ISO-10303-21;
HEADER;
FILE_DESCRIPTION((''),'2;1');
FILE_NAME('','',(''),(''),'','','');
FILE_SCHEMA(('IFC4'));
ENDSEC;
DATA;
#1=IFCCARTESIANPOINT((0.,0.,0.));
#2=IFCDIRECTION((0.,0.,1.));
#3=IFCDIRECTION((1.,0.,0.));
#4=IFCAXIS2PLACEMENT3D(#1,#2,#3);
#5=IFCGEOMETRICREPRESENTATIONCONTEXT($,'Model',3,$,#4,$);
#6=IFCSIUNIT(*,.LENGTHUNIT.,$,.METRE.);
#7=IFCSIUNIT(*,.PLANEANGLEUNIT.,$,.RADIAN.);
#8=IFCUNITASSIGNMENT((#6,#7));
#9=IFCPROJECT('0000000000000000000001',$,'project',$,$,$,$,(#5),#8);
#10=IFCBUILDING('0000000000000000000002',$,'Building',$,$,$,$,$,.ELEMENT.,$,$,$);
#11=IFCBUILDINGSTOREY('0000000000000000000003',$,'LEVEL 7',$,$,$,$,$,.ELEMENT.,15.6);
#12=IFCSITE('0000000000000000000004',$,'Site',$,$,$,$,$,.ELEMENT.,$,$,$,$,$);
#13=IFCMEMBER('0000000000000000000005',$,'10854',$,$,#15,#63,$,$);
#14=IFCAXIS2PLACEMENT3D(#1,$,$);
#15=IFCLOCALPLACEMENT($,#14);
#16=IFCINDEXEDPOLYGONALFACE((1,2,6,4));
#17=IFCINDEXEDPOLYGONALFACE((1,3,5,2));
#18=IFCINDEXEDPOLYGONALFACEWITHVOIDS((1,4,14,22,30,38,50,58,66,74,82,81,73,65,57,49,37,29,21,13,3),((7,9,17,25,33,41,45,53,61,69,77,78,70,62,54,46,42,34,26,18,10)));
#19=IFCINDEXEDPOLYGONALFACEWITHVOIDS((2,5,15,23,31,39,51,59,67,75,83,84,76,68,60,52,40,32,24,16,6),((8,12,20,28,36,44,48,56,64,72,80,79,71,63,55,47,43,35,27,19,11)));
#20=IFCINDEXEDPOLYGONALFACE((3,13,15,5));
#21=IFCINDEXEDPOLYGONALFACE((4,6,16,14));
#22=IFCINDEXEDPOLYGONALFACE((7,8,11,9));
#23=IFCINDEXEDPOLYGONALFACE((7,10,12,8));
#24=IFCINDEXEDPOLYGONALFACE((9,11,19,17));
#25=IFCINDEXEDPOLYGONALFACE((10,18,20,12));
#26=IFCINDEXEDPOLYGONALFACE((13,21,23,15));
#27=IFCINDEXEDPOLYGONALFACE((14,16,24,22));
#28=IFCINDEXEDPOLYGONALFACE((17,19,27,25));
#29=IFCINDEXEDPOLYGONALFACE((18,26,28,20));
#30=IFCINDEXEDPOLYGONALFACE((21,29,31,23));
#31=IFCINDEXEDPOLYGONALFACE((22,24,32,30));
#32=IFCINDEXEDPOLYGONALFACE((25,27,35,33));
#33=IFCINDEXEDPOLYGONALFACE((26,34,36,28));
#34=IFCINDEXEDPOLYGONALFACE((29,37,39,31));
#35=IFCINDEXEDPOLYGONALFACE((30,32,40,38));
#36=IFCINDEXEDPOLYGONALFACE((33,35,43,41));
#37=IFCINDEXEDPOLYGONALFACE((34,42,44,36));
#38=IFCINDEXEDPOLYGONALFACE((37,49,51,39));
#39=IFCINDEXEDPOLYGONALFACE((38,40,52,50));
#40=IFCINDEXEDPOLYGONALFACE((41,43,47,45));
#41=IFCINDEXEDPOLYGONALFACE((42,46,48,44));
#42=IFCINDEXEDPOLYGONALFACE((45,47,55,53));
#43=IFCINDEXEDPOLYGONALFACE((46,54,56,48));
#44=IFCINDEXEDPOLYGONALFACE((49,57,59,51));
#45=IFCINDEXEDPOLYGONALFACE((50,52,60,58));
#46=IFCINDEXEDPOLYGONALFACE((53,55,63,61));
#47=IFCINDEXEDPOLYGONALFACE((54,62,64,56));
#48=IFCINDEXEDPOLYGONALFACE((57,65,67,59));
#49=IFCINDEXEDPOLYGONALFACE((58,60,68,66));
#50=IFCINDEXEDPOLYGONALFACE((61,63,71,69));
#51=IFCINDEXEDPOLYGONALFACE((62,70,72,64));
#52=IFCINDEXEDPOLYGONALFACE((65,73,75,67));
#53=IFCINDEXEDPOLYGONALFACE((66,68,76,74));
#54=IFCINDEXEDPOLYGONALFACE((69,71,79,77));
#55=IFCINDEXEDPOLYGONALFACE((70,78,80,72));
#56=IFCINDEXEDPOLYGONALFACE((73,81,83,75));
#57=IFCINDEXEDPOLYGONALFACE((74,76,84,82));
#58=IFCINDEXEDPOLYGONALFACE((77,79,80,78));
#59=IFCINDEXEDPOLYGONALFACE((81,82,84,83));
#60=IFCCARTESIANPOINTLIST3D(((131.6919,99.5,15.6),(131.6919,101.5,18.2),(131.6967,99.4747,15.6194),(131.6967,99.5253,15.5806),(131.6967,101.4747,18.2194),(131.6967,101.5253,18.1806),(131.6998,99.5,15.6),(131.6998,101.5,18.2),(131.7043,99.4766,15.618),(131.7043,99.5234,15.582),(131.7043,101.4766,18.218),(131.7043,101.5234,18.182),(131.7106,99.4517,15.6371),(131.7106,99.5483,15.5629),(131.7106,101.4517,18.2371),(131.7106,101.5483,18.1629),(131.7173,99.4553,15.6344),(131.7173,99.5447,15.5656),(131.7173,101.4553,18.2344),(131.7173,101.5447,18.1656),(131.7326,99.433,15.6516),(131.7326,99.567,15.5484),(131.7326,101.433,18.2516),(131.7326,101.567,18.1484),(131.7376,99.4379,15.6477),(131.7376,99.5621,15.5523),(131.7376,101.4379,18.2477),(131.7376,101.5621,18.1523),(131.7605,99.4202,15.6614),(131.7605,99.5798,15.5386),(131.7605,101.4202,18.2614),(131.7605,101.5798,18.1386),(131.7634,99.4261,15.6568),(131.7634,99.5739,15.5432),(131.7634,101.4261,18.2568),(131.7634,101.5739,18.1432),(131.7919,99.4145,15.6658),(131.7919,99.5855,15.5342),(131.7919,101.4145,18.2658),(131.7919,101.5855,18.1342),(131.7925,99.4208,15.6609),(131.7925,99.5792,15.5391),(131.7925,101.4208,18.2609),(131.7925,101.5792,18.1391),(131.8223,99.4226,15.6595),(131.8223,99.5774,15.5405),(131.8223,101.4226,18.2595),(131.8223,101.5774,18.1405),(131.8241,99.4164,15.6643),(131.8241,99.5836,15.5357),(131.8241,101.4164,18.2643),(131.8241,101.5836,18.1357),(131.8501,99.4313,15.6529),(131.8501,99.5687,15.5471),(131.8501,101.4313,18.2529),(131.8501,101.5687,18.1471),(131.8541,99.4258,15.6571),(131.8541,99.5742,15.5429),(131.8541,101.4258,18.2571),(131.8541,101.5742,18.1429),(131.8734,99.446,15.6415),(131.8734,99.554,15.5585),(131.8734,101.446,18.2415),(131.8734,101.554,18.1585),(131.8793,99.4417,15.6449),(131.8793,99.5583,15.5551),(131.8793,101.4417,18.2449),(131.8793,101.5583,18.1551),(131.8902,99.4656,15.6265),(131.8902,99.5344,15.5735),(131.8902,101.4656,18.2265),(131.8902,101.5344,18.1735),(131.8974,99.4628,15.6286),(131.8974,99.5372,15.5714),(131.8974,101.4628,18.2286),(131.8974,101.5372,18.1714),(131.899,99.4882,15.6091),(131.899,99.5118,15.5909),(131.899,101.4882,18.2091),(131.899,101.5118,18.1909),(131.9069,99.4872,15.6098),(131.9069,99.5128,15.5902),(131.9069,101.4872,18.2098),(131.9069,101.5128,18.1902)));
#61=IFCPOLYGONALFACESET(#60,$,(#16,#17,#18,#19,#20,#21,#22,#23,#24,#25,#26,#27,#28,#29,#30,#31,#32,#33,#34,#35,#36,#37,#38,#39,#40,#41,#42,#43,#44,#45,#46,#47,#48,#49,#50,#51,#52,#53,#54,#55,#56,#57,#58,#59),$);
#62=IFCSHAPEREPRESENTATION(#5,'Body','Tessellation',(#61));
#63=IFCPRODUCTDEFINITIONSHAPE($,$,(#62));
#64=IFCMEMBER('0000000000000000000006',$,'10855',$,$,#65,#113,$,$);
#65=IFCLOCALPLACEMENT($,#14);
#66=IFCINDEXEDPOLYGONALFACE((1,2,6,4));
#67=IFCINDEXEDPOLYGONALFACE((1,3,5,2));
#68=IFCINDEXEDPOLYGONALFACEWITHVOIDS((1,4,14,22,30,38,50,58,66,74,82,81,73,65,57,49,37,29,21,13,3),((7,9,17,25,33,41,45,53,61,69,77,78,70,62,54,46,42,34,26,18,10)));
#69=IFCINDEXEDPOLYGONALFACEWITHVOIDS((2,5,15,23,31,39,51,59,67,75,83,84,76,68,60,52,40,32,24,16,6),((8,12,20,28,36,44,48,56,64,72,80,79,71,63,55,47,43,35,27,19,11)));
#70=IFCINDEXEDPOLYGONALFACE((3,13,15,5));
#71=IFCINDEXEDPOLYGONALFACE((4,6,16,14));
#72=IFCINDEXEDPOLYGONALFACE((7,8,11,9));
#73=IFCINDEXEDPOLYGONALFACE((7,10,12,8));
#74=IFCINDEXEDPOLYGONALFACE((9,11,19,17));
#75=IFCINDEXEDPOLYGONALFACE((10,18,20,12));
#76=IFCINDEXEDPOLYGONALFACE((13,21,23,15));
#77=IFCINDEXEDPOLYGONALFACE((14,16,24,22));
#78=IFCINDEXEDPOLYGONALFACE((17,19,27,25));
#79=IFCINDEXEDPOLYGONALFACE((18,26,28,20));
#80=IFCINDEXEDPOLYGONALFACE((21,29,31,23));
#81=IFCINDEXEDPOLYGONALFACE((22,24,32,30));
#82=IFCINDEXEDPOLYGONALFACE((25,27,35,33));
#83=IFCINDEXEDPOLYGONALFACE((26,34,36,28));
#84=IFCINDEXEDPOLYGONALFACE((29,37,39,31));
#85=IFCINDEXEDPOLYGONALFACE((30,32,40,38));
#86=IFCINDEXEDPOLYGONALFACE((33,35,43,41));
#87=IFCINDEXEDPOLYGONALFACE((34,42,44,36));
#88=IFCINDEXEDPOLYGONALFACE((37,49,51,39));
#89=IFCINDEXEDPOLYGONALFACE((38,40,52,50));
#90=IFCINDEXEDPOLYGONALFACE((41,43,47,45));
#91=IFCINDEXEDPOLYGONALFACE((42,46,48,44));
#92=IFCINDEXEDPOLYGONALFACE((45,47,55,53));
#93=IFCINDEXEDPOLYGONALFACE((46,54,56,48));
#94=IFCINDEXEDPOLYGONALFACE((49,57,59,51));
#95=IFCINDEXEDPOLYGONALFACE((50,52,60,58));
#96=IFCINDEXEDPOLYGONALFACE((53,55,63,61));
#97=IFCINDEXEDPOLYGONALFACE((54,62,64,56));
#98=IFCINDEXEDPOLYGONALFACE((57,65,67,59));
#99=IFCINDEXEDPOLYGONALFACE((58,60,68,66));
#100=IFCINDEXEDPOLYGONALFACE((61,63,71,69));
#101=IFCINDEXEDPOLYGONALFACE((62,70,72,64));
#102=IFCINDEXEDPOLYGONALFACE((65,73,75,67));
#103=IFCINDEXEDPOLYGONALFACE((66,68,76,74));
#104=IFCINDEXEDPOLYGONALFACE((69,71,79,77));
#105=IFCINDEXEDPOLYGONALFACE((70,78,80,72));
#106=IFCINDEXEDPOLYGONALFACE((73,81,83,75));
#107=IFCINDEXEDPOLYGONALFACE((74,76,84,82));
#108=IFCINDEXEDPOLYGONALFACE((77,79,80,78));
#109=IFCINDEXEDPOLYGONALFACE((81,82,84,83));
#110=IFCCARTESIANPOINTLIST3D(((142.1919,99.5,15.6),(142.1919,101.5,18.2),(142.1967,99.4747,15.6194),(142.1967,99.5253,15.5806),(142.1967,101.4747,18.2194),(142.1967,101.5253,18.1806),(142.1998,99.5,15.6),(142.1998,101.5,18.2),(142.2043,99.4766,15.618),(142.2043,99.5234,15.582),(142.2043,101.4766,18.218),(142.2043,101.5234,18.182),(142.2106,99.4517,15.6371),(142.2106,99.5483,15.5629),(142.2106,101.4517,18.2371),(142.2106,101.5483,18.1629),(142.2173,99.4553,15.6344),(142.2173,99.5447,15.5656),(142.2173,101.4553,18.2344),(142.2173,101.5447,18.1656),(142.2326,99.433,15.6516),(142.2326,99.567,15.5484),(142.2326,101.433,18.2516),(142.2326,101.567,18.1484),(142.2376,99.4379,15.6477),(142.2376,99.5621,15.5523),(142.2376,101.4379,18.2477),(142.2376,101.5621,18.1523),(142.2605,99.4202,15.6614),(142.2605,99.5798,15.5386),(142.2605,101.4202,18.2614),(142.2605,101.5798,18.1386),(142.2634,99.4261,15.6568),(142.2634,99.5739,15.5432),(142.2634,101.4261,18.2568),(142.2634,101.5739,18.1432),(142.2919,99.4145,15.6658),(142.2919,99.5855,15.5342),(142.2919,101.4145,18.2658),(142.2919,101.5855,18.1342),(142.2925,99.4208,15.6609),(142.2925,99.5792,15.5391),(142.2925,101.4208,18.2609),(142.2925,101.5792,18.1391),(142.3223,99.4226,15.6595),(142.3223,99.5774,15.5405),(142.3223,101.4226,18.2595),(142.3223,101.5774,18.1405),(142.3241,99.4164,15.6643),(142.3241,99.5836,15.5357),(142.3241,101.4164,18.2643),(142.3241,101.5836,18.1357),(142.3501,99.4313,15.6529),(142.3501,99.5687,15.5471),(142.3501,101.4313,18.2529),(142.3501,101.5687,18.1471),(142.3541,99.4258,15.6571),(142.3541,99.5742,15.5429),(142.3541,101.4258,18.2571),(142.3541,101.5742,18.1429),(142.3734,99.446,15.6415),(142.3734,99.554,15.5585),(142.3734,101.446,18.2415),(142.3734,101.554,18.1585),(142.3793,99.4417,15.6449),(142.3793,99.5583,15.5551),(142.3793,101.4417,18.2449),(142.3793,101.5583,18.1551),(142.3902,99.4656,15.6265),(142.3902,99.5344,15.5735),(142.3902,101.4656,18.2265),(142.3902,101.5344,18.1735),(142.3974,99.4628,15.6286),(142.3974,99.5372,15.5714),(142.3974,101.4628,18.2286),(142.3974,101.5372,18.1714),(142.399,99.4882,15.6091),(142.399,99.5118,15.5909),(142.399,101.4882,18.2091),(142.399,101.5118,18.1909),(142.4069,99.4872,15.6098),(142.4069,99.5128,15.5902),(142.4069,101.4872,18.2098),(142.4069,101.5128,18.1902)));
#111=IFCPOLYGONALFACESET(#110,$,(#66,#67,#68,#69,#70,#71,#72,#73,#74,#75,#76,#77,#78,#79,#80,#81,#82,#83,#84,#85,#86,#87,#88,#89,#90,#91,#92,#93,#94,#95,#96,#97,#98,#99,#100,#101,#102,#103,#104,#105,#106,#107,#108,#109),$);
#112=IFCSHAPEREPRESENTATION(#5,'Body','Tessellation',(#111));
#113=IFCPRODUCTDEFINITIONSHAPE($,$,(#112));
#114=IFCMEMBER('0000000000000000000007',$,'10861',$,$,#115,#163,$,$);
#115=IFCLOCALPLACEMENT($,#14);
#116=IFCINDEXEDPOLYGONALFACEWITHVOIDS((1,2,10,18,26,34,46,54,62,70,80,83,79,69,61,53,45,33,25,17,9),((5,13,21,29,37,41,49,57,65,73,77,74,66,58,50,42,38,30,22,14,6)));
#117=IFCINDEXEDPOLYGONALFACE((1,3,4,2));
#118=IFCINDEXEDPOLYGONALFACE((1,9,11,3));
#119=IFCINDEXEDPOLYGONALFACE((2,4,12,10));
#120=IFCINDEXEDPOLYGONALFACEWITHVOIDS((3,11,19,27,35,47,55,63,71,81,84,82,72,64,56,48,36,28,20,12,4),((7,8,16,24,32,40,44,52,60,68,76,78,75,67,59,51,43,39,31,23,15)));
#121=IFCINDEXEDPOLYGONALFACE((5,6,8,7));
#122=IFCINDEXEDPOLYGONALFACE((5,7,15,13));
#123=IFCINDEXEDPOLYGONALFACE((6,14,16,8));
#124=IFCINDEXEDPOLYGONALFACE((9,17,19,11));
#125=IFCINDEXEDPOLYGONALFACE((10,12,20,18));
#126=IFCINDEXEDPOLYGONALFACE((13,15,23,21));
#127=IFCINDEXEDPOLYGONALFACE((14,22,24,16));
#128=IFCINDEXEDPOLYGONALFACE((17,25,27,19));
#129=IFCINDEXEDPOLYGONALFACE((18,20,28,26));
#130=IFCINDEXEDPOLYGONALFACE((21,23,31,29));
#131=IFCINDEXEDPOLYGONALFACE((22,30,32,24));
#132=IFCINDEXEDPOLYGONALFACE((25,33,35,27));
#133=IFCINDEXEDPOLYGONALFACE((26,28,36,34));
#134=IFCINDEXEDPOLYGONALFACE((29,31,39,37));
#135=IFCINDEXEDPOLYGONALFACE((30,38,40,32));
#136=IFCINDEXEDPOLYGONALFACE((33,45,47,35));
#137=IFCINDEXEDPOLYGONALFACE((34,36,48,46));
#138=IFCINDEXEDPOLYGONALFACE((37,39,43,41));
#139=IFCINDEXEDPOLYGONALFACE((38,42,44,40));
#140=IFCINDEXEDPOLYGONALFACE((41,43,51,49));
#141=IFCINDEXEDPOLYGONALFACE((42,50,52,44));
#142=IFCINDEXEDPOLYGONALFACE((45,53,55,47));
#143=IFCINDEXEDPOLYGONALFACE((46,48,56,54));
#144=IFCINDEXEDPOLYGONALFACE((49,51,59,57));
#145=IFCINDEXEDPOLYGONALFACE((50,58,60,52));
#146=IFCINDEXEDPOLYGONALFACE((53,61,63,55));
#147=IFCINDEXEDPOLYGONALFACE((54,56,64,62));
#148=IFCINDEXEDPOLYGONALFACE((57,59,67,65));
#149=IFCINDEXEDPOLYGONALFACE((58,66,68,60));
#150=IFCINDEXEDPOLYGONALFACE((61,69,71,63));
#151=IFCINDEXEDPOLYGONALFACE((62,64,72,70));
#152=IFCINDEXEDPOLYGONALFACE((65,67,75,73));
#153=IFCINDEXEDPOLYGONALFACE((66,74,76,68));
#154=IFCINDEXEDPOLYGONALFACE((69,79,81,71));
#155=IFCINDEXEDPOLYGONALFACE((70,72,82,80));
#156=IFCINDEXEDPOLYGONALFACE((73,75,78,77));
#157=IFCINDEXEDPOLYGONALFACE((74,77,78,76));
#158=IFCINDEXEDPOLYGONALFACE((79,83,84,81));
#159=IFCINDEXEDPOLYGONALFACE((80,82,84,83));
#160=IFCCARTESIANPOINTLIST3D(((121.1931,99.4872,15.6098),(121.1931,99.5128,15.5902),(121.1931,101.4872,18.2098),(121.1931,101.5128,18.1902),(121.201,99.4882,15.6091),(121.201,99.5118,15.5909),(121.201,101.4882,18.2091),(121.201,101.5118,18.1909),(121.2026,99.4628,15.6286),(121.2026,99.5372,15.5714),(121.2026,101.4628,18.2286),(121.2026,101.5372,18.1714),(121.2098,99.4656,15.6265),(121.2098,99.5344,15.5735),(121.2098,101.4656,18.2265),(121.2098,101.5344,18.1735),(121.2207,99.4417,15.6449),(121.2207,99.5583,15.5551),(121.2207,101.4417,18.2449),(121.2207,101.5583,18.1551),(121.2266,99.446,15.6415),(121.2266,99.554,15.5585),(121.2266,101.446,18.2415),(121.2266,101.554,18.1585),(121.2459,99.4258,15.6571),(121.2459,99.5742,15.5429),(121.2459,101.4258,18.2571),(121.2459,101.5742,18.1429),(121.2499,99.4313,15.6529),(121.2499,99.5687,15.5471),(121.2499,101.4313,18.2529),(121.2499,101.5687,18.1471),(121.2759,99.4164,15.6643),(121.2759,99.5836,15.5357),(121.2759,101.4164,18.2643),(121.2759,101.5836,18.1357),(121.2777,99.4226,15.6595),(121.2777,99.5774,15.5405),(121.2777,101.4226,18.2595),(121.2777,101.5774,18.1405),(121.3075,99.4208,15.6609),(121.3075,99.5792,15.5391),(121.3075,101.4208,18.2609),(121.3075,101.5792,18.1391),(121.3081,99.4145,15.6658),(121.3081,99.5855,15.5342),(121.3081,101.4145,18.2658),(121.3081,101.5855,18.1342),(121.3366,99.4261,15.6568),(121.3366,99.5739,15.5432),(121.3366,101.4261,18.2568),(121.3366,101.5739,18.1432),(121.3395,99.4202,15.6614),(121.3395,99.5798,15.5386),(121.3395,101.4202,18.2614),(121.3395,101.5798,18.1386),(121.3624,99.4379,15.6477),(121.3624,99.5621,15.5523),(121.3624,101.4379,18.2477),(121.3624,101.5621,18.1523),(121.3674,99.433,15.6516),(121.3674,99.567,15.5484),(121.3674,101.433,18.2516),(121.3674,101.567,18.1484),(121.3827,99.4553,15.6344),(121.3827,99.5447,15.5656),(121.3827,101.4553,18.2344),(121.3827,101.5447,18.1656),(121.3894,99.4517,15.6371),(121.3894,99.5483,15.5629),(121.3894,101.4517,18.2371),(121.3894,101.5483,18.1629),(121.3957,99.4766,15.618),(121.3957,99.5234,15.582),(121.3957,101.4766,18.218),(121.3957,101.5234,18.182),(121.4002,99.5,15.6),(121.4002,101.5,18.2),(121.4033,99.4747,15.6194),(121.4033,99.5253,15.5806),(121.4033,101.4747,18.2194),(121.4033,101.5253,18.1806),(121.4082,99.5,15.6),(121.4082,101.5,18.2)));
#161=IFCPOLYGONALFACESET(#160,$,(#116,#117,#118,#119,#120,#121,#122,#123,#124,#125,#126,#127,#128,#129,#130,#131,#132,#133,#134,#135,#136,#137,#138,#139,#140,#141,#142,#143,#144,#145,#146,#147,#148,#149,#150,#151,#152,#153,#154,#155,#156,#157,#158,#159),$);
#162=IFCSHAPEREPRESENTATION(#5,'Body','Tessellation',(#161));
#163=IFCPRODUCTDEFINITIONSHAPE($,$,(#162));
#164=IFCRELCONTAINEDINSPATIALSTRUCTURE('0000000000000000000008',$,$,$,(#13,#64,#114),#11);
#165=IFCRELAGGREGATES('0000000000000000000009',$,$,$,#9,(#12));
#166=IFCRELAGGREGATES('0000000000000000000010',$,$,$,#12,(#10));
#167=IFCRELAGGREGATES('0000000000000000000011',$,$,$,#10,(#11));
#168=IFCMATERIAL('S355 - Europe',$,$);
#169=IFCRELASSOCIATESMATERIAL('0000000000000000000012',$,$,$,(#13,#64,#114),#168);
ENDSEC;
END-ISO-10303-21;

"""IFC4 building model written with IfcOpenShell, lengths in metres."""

from ifc_helpers import new_model, si_unit, frame, origin_with_axes, origin_2d_with_axis, place, context, project, spatial, hollow_circle, extrude, material, material_profile, profile_set, profile_usage, element, save


model = new_model("IFC4")

# Units and contexts
model_context = context("Model", 3, world=origin_with_axes())
ifc_project = project(units=[si_unit("LENGTHUNIT", "METRE"), si_unit("PLANEANGLEUNIT", "RADIAN")], contexts=[model_context])

# Site, building, storey
site = spatial("IfcSite", under=ifc_project, Name="Site", CompositionType="ELEMENT")
building = spatial("IfcBuilding", under=site, Name="Building", CompositionType="ELEMENT")
storey = spatial("IfcBuildingStorey", under=building, Name="LEVEL 7", CompositionType="ELEMENT", Elevation=15.6)

# Shared definitions
ifc_material = material(Name="S355 - Europe")

# Members
ifc_material_profile_1 = material_profile(ifc_material, hollow_circle(Radius=0.1081, WallThickness=0.008, at=origin_2d_with_axis()))
ifc_profile_set_1 = profile_set([ifc_material_profile_1])
ifc_profile_usage_1 = profile_usage(ifc_profile_set_1, cardinal=10)
member_1_placement = place(None, frame((131.8, 99.5, 15.6), z_axis=(0.0, 0.609711, 0.792624), x_axis=(-1.0, 0.0, 0.0)))
element("IfcMember", 1, at=member_1_placement, inside=storey, material=ifc_profile_usage_1, Name="10854", context=model_context, shape_type="SweptSolid", body=[
    extrude(hollow_circle(Radius=0.1081, WallThickness=0.008, at=origin_2d_with_axis()), origin_with_axes(), (0.0, 0.0, 1.0), 3.2802),
])
ifc_material_profile_2 = material_profile(ifc_material, hollow_circle(Radius=0.1081, WallThickness=0.008, at=origin_2d_with_axis()))
ifc_profile_set_2 = profile_set([ifc_material_profile_2])
ifc_profile_usage_2 = profile_usage(ifc_profile_set_2, cardinal=10)
member_2_placement = place(None, frame((142.3, 99.5, 15.6), z_axis=(0.0, 0.609711, 0.792624), x_axis=(-1.0, 0.0, 0.0)))
element("IfcMember", 2, at=member_2_placement, inside=storey, material=ifc_profile_usage_2, Name="10855", context=model_context, shape_type="SweptSolid", body=[
    extrude(hollow_circle(Radius=0.1081, WallThickness=0.008, at=origin_2d_with_axis()), origin_with_axes(), (0.0, 0.0, 1.0), 3.2802),
])
ifc_material_profile_3 = material_profile(ifc_material, hollow_circle(Radius=0.1081, WallThickness=0.008, at=origin_2d_with_axis()))
ifc_profile_set_3 = profile_set([ifc_material_profile_3])
ifc_profile_usage_3 = profile_usage(ifc_profile_set_3, cardinal=10)
member_3_placement = place(None, frame((121.3, 101.5, 18.2), z_axis=(0.0, -0.609711, -0.792624), x_axis=(1.0, 0.0, 0.0)))
element("IfcMember", 3, at=member_3_placement, inside=storey, material=ifc_profile_usage_3, Name="10861", context=model_context, shape_type="SweptSolid", body=[
    extrude(hollow_circle(Radius=0.1081, WallThickness=0.008, at=origin_2d_with_axis()), origin_with_axes(), (0.0, 0.0, 1.0), 3.2802),
])

save(model, "model.ifc")
